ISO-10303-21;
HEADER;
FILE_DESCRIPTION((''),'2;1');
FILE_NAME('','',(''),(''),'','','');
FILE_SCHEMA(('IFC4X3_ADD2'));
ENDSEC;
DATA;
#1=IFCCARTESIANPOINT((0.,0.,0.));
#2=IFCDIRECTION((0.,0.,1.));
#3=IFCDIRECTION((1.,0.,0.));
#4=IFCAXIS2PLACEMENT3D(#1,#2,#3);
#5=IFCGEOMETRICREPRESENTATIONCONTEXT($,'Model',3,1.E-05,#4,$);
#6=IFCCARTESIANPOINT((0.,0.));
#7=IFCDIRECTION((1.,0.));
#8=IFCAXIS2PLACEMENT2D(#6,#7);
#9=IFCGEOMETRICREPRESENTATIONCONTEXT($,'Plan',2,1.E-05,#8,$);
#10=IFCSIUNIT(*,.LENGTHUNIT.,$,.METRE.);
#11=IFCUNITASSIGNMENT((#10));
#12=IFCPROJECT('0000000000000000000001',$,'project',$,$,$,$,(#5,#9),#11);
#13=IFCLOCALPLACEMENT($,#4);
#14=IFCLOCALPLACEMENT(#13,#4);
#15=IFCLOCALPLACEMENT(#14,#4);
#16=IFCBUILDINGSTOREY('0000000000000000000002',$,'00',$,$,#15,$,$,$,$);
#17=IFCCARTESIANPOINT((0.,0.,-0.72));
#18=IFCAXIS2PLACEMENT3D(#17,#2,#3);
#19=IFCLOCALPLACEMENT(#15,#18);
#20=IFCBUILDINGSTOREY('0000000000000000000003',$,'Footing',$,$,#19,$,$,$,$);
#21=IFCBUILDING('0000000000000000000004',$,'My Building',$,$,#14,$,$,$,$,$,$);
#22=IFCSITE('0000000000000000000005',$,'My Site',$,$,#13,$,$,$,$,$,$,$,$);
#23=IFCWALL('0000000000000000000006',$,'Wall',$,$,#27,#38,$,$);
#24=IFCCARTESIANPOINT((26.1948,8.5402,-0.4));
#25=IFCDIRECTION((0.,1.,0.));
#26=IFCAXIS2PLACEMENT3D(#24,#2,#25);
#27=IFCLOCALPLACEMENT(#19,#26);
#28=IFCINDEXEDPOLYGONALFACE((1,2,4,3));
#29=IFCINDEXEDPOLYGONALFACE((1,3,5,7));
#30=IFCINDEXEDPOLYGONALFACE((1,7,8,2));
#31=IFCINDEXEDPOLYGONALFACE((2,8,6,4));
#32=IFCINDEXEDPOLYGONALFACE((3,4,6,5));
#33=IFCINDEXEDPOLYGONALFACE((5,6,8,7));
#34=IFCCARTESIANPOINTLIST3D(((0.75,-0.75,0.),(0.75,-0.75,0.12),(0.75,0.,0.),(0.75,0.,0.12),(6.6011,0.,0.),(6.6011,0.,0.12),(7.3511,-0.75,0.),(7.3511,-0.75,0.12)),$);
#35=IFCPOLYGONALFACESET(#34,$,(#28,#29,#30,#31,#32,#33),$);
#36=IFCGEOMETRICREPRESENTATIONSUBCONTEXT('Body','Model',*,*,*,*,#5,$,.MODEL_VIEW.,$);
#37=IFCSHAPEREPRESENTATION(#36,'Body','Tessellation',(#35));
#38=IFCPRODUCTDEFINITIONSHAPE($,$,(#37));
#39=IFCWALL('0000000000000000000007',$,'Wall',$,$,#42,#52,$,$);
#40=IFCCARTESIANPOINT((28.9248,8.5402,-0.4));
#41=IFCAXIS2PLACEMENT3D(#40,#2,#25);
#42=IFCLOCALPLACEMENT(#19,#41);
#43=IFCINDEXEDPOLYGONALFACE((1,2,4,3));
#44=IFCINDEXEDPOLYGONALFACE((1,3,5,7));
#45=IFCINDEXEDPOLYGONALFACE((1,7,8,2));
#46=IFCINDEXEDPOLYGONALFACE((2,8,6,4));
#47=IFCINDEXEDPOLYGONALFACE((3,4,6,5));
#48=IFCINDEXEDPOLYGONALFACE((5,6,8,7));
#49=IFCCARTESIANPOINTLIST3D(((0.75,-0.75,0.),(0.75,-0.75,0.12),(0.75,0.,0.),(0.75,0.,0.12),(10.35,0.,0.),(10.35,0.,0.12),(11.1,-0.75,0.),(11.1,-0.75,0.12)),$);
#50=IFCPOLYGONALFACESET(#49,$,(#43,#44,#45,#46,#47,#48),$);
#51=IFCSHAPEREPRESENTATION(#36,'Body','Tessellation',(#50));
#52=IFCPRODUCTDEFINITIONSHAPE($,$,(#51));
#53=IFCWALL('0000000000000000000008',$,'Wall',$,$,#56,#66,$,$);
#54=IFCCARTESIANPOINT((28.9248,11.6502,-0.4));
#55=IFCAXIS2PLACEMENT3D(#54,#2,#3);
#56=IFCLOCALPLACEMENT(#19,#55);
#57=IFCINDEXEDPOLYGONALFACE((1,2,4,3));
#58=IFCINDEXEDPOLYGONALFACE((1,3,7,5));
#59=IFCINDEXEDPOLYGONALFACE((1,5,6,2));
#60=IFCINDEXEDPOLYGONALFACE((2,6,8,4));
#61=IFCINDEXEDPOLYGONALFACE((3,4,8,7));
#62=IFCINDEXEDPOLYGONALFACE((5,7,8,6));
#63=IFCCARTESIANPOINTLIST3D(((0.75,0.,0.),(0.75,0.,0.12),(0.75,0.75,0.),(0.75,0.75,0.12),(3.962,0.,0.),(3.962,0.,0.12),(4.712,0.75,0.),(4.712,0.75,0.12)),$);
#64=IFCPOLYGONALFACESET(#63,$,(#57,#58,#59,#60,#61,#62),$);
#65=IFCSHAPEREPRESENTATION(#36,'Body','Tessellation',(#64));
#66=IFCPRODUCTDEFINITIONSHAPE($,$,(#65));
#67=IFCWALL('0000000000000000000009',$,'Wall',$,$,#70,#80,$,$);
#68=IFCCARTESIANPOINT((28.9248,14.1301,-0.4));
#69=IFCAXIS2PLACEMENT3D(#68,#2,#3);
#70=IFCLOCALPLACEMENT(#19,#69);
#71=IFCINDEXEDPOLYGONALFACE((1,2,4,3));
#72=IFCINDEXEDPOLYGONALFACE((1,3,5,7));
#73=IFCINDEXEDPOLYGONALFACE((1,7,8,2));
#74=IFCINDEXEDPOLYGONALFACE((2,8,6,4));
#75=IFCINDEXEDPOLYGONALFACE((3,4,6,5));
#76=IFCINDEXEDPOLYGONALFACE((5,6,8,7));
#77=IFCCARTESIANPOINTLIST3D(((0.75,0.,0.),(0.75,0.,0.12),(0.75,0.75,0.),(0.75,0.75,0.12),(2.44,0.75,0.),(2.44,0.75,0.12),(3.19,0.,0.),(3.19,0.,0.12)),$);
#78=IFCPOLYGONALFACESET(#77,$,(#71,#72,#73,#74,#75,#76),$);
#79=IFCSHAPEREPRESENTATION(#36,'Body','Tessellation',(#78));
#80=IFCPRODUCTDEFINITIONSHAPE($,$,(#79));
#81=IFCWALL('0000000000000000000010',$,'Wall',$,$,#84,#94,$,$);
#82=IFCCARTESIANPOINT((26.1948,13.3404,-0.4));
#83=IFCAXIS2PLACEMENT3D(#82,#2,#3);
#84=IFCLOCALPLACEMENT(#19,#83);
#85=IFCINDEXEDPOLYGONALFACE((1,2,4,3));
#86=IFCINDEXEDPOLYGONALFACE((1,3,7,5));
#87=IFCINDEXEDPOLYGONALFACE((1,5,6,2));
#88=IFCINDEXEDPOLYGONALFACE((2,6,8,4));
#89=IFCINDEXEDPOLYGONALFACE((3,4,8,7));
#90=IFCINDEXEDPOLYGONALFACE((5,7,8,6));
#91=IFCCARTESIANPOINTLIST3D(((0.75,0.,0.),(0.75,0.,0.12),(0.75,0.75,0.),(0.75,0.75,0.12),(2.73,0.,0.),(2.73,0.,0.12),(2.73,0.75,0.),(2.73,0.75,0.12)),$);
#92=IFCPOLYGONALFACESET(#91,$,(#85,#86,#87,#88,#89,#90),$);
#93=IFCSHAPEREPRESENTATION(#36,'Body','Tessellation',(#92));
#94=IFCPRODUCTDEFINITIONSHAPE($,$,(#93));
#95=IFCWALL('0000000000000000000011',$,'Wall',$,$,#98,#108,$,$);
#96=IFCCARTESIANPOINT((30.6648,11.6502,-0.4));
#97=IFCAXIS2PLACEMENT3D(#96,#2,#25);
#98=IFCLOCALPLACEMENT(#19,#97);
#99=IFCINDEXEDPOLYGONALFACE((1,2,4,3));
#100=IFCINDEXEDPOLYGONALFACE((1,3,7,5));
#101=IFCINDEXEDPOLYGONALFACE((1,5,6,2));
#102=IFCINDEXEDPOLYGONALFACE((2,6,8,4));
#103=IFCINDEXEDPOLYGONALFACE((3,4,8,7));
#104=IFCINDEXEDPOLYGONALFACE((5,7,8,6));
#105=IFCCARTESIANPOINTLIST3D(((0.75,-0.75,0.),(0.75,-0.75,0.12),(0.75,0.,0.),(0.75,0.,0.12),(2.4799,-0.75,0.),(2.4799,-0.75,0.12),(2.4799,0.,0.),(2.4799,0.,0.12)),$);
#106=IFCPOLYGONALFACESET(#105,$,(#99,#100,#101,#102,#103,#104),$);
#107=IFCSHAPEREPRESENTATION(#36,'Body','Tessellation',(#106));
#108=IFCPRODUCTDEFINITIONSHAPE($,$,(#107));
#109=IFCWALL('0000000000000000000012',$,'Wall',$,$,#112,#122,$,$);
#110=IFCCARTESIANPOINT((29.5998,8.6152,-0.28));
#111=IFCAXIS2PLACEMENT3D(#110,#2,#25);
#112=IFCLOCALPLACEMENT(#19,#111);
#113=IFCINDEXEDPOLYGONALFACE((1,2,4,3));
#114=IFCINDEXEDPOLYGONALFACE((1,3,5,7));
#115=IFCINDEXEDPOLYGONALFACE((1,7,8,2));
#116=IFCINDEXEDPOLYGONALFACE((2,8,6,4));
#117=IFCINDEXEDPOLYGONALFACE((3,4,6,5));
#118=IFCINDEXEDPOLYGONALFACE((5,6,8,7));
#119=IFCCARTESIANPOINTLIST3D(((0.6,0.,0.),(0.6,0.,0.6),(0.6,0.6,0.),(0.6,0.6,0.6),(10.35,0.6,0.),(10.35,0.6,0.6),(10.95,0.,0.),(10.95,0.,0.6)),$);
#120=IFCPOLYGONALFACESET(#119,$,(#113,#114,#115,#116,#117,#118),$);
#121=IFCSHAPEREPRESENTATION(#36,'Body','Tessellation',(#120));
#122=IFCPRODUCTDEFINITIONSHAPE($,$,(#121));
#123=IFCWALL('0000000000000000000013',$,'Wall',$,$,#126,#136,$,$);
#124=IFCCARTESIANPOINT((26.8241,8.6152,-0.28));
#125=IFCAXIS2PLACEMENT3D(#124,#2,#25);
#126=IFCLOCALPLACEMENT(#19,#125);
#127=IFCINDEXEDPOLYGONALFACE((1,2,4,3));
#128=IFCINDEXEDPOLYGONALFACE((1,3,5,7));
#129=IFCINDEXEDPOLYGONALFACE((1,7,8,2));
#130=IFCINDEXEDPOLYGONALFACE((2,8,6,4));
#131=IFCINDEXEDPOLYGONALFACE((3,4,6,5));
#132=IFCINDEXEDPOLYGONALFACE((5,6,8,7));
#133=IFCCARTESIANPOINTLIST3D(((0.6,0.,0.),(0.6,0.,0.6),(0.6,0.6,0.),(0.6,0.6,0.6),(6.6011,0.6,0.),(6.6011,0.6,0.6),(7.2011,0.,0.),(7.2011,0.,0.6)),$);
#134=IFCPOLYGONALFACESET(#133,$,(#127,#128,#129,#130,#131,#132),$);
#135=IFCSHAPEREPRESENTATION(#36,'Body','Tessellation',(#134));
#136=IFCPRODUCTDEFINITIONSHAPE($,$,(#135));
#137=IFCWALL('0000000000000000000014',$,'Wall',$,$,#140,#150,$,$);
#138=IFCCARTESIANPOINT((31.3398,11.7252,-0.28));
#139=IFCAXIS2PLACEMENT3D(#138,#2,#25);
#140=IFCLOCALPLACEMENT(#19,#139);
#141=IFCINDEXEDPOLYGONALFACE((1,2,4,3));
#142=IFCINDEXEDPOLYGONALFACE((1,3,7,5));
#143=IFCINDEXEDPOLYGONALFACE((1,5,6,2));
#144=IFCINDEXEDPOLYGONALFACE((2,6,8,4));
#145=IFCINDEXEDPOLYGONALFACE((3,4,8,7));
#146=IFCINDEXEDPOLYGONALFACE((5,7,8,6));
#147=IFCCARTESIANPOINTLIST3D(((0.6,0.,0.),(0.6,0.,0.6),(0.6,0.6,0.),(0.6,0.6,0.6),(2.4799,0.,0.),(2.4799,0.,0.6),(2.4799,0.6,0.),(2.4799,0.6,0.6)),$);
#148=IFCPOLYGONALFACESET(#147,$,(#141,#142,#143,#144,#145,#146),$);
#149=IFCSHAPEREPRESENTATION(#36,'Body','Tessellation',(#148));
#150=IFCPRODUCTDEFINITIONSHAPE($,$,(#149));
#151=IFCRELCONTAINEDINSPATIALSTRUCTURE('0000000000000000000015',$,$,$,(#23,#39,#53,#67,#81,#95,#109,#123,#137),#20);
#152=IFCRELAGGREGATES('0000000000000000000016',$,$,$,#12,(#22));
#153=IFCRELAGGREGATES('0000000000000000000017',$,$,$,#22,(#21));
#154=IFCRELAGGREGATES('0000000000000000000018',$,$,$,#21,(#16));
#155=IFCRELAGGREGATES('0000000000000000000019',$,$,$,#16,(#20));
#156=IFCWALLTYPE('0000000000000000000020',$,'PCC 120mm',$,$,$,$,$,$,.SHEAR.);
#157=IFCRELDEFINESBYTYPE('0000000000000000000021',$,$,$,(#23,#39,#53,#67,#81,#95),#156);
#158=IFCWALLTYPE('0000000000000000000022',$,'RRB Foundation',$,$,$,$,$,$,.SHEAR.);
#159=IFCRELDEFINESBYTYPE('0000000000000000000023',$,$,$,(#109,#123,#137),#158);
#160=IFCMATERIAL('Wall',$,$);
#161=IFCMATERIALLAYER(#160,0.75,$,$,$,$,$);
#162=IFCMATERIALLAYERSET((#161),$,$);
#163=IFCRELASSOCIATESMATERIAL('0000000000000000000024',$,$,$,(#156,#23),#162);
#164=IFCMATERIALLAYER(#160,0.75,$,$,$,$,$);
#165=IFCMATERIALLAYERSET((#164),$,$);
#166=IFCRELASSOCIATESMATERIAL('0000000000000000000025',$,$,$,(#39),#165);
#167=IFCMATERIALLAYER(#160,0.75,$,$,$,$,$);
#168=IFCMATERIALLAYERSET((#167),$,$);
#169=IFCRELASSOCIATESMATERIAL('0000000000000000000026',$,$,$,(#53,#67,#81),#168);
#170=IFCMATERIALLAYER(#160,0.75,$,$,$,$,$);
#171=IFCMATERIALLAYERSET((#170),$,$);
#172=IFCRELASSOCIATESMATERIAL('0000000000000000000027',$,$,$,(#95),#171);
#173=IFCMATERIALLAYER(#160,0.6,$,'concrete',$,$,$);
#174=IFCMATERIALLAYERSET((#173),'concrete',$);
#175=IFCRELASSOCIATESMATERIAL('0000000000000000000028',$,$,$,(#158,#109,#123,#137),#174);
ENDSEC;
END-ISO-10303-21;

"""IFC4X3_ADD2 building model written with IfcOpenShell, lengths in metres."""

from ifc_helpers import new_model, si_unit, frame, origin_with_axes, origin_2d_with_axis, place, context, subcontext, project, spatial, line, indexed_curve, outline, extrude, material, layer, layer_set, layer_usage, type_object, element, save


model = new_model("IFC4X3_ADD2")

# Units and contexts
model_context = context("Model", 3, precision=1e-05, world=origin_with_axes())
plan_context = context("Plan", 2, precision=1e-05, world=origin_2d_with_axis())
body_context = subcontext(model_context, "Body", "Model", "MODEL_VIEW")
ifc_project = project(units=[si_unit("LENGTHUNIT", "METRE")], contexts=[model_context, plan_context])

# Site, building, storeys
site_placement = place(None, origin_with_axes())
site = spatial("IfcSite", under=ifc_project, at=site_placement, Name="My Site")
building_placement = place(site_placement, origin_with_axes())
building = spatial("IfcBuilding", under=site, at=building_placement, Name="My Building")
storey_1_placement = place(building_placement, origin_with_axes())
storey_1 = spatial("IfcBuildingStorey", under=building, at=storey_1_placement, Name="00")
storey_2_placement = place(storey_1_placement, frame((0.0, 0.0, -0.72), z_axis=(0.0, 0.0, 1.0), x_axis=(1.0, 0.0, 0.0)))
storey_2 = spatial("IfcBuildingStorey", under=storey_1, at=storey_2_placement, Name="Footing")

# Shared definitions
ifc_material_1 = material(Name="Wall")

# Walls
ifc_layer_1 = layer(ifc_material_1, 0.75)
ifc_layer_set_1 = layer_set([ifc_layer_1])
ifc_layer_usage_1 = layer_usage(ifc_layer_set_1, "AXIS2", "NEGATIVE", 0.0)
wall_type_1 = type_object("IfcWallType", Name="PCC 120mm", PredefinedType="SHEAR", material=ifc_layer_set_1)
wall_1_placement = place(storey_2_placement, frame((26.1948, 8.5402, -0.4), z_axis=(0.0, 0.0, 1.0), x_axis=(0.0, 1.0, 0.0)))
element("IfcWall", 1, at=wall_1_placement, inside=storey_2, type_object=wall_type_1, material=ifc_layer_usage_1, Name="Wall", context=body_context, shape_type="SweptSolid", body=[
    extrude(outline(indexed_curve([(0.75, -0.75), (0.75, 0.0), (6.6011, 0.0), (7.3511, -0.75)], segments=[line(1, 2, 3, 4, 1)])), origin_with_axes(), (0.0, 0.0, 1.0), 0.12),
])
ifc_layer_2 = layer(ifc_material_1, 0.75)
ifc_layer_set_2 = layer_set([ifc_layer_2])
ifc_layer_usage_2 = layer_usage(ifc_layer_set_2, "AXIS2", "NEGATIVE", 0.0)
wall_2_placement = place(storey_2_placement, frame((28.9248, 8.5402, -0.4), z_axis=(0.0, 0.0, 1.0), x_axis=(0.0, 1.0, 0.0)))
element("IfcWall", 2, at=wall_2_placement, inside=storey_2, type_object=wall_type_1, material=ifc_layer_usage_2, Name="Wall", context=body_context, shape_type="SweptSolid", body=[
    extrude(outline(indexed_curve([(0.75, -0.75), (0.75, 0.0), (10.35, 0.0), (11.1, -0.75)], segments=[line(1, 2, 3, 4, 1)])), origin_with_axes(), (0.0, 0.0, 1.0), 0.12),
])
ifc_layer_3 = layer(ifc_material_1, 0.75)
ifc_layer_set_3 = layer_set([ifc_layer_3])
ifc_layer_4 = layer(ifc_material_1, 0.75)
ifc_layer_set_4 = layer_set([ifc_layer_4])
ifc_layer_usage_3 = layer_usage(ifc_layer_set_4, "AXIS2", "POSITIVE", 0.0)
wall_3_placement = place(storey_2_placement, frame((28.9248, 11.6502, -0.4), z_axis=(0.0, 0.0, 1.0), x_axis=(1.0, 0.0, 0.0)))
element("IfcWall", 3, at=wall_3_placement, inside=storey_2, type_object=wall_type_1, material=ifc_layer_usage_3, Name="Wall", context=body_context, shape_type="SweptSolid", body=[
    extrude(outline(indexed_curve([(0.75, 0.0), (0.75, 0.75), (4.712, 0.75), (3.962, 0.0)], segments=[line(1, 2, 3, 4, 1)])), origin_with_axes(), (0.0, 0.0, 1.0), 0.12),
])
ifc_layer_usage_4 = layer_usage(ifc_layer_set_4, "AXIS2", "POSITIVE", 0.0)
wall_4_placement = place(storey_2_placement, frame((28.9248, 14.1301, -0.4), z_axis=(0.0, 0.0, 1.0), x_axis=(1.0, 0.0, 0.0)))
element("IfcWall", 4, at=wall_4_placement, inside=storey_2, type_object=wall_type_1, material=ifc_layer_usage_4, Name="Wall", context=body_context, shape_type="SweptSolid", body=[
    extrude(outline(indexed_curve([(0.75, 0.0), (0.75, 0.75), (2.44, 0.75), (3.19, 0.0)], segments=[line(1, 2, 3, 4, 1)])), origin_with_axes(), (0.0, 0.0, 1.0), 0.12),
])
ifc_layer_usage_5 = layer_usage(ifc_layer_set_4, "AXIS2", "POSITIVE", 0.0)
wall_5_placement = place(storey_2_placement, frame((26.1948, 13.3404, -0.4), z_axis=(0.0, 0.0, 1.0), x_axis=(1.0, 0.0, 0.0)))
element("IfcWall", 5, at=wall_5_placement, inside=storey_2, type_object=wall_type_1, material=ifc_layer_usage_5, Name="Wall", context=body_context, shape_type="SweptSolid", body=[
    extrude(outline(indexed_curve([(0.75, 0.0), (0.75, 0.75), (2.73, 0.75), (2.73, 0.0)], segments=[line(1, 2, 3, 4, 1)])), origin_with_axes(), (0.0, 0.0, 1.0), 0.12),
])
ifc_layer_usage_6 = layer_usage(ifc_layer_set_3, "AXIS2", "NEGATIVE", 0.0)
wall_6_placement = place(storey_2_placement, frame((30.6648, 11.6502, -0.4), z_axis=(0.0, 0.0, 1.0), x_axis=(0.0, 1.0, 0.0)))
element("IfcWall", 6, at=wall_6_placement, inside=storey_2, type_object=wall_type_1, material=ifc_layer_usage_6, Name="Wall", context=body_context, shape_type="SweptSolid", body=[
    extrude(outline(indexed_curve([(0.75, -0.75), (0.75, 0.0), (2.4799, 0.0), (2.4799, -0.75)], segments=[line(1, 2, 3, 4, 1)])), origin_with_axes(), (0.0, 0.0, 1.0), 0.12),
])
ifc_layer_5 = layer(ifc_material_1, 0.6, Name="concrete")
ifc_layer_set_5 = layer_set([ifc_layer_5], Name="concrete")
ifc_layer_usage_7 = layer_usage(ifc_layer_set_5, "AXIS2", "POSITIVE", 0.0)
wall_type_2 = type_object("IfcWallType", Name="RRB Foundation", PredefinedType="SHEAR", material=ifc_layer_set_5)
wall_7_placement = place(storey_2_placement, frame((29.5998, 8.6152, -0.28), z_axis=(0.0, 0.0, 1.0), x_axis=(0.0, 1.0, 0.0)))
element("IfcWall", 7, at=wall_7_placement, inside=storey_2, type_object=wall_type_2, material=ifc_layer_usage_7, Name="Wall", context=body_context, shape_type="SweptSolid", body=[
    extrude(outline(indexed_curve([(0.6, 0.0), (0.6, 0.6), (10.35, 0.6), (10.95, 0.0)], segments=[line(1, 2, 3, 4, 1)])), origin_with_axes(), (0.0, 0.0, 1.0), 0.6),
])
ifc_layer_usage_8 = layer_usage(ifc_layer_set_5, "AXIS2", "POSITIVE", 0.0)
wall_8_placement = place(storey_2_placement, frame((26.8241, 8.6152, -0.28), z_axis=(0.0, 0.0, 1.0), x_axis=(0.0, 1.0, 0.0)))
element("IfcWall", 8, at=wall_8_placement, inside=storey_2, type_object=wall_type_2, material=ifc_layer_usage_8, Name="Wall", context=body_context, shape_type="SweptSolid", body=[
    extrude(outline(indexed_curve([(0.6, 0.0), (0.6, 0.6), (6.6011, 0.6), (7.2011, 0.0)], segments=[line(1, 2, 3, 4, 1)])), origin_with_axes(), (0.0, 0.0, 1.0), 0.6),
])
ifc_layer_usage_9 = layer_usage(ifc_layer_set_5, "AXIS2", "POSITIVE", 0.0)
wall_9_placement = place(storey_2_placement, frame((31.3398, 11.7252, -0.28), z_axis=(0.0, 0.0, 1.0), x_axis=(0.0, 1.0, 0.0)))
element("IfcWall", 9, at=wall_9_placement, inside=storey_2, type_object=wall_type_2, material=ifc_layer_usage_9, Name="Wall", context=body_context, shape_type="SweptSolid", body=[
    extrude(outline(indexed_curve([(0.6, 0.0), (0.6, 0.6), (2.4799, 0.6), (2.4799, 0.0)], segments=[line(1, 2, 3, 4, 1)])), origin_with_axes(), (0.0, 0.0, 1.0), 0.6),
])

save(model, "model.ifc")
